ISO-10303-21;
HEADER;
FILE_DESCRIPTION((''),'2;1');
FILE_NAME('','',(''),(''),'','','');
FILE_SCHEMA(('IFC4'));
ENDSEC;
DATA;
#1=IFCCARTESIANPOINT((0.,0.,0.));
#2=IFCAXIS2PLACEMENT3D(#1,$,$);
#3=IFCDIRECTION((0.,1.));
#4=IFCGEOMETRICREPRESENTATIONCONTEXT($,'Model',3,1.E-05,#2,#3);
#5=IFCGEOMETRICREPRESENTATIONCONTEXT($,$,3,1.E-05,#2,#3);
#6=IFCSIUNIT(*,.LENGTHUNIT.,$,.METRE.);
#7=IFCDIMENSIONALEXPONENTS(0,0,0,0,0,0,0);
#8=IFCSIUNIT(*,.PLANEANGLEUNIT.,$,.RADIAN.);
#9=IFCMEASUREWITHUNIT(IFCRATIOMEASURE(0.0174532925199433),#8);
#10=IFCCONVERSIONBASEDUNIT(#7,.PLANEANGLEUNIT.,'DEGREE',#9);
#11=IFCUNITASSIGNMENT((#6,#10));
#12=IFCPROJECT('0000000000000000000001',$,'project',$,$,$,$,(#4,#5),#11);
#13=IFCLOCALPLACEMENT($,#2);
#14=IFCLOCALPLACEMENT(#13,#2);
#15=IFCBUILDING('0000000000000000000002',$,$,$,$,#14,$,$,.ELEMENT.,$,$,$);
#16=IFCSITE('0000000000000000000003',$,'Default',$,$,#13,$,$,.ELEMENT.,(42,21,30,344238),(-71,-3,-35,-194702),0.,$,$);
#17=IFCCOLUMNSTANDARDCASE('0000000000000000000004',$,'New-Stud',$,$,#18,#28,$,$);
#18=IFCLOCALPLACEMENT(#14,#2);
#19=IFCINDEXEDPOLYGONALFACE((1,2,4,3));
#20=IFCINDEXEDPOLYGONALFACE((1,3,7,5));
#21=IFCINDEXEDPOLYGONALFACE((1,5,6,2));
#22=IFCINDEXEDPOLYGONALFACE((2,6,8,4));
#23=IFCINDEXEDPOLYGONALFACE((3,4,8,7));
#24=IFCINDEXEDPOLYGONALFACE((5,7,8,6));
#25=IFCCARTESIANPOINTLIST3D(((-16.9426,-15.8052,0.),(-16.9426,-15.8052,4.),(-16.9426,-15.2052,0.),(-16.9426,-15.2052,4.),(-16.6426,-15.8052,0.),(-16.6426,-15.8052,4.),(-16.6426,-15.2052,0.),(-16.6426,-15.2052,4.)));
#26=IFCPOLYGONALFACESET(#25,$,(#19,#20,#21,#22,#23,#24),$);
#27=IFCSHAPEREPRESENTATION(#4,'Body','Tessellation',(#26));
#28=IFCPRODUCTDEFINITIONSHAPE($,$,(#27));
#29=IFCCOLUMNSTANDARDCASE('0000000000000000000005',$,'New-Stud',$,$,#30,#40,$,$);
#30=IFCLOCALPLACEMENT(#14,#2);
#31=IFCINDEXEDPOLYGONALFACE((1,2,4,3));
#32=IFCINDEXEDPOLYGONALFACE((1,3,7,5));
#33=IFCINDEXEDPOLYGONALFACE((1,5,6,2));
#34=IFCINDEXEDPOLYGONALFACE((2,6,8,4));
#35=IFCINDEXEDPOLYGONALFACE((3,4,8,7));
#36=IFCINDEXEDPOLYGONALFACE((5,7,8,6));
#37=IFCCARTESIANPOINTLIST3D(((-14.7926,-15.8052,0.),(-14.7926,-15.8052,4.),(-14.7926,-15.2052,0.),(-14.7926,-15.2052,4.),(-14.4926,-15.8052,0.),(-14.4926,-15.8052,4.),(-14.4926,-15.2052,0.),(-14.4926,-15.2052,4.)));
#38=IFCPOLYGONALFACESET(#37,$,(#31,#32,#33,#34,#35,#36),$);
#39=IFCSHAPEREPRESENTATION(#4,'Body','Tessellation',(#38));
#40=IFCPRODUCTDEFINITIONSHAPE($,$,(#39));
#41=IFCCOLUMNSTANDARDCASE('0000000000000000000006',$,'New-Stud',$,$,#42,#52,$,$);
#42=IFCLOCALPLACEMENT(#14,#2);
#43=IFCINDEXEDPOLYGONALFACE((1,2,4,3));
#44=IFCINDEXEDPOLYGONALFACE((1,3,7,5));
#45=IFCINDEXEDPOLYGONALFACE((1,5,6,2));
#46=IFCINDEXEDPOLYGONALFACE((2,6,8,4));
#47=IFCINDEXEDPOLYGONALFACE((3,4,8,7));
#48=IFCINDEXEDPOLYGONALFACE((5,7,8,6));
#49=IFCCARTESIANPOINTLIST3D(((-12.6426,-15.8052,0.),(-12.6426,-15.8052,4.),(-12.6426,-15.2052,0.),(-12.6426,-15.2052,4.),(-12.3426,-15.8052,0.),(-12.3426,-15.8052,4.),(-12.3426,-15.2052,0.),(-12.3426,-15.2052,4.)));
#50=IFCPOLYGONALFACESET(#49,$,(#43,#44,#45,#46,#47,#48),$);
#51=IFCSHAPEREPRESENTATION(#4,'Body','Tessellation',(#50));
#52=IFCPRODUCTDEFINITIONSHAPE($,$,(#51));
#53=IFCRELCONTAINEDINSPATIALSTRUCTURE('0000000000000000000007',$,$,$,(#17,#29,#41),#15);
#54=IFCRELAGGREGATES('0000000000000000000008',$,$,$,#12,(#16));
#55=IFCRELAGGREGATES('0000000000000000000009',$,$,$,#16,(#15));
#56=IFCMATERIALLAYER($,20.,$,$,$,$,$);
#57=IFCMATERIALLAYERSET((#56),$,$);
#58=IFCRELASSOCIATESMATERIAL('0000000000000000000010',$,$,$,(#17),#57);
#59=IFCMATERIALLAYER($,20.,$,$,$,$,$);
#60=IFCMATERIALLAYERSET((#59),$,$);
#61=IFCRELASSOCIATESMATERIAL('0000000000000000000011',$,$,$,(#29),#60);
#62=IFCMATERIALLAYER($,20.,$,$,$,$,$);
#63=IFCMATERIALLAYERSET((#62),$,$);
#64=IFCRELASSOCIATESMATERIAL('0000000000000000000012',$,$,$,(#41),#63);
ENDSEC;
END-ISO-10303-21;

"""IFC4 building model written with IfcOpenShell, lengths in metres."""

from ifc_helpers import new_model, entity, si_unit, converted_unit, direction, frame, origin, origin_with_axes, origin_2d, place, context, project, spatial, rectangle, extrude, layer, layer_set, layer_usage, element, save


model = new_model("IFC4")

# Units and contexts
model_context = context("Model", 3, precision=1e-05, world=origin(), true_north=direction((0.0, 1.0)))
context_of_model = context(None, 3, precision=1e-05, world=origin(), true_north=direction((0.0, 1.0)))
ifc_project = project(units=[si_unit("LENGTHUNIT", "METRE"), converted_unit("PLANEANGLEUNIT", "DEGREE", entity("IfcRatioMeasure", 0.0174532925199433), si_unit("PLANEANGLEUNIT", "RADIAN"), dimensions=[0, 0, 0, 0, 0, 0, 0])], contexts=[model_context, context_of_model])

# Site, building
site_placement = place(None, origin())
site = spatial("IfcSite", under=ifc_project, at=site_placement, Name="Default", CompositionType="ELEMENT", RefLatitude=(42, 21, 30, 344238), RefLongitude=(-71, -3, -35, -194702), RefElevation=0.0)
building_placement = place(site_placement, origin())
building = spatial("IfcBuilding", under=site, at=building_placement, CompositionType="ELEMENT")

# Columns
ifc_layer_1 = layer(None, 20.0)
ifc_layer_set_1 = layer_set([ifc_layer_1])
ifc_layer_usage_1 = layer_usage(ifc_layer_set_1, "AXIS2", "POSITIVE", 150.0)
placement_1 = place(building_placement, origin())
placement_2 = place(placement_1, frame((-16.7926, -15.5052, 0.0), z_axis=(0.0, 0.0, 1.0), x_axis=(0.0, 1.0, 0.0)))
column_1_placement = place(placement_2, origin_with_axes())
element("IfcColumnStandardCase", 1, at=column_1_placement, inside=building, material=ifc_layer_usage_1, Name="New-Stud", context=model_context, shape_type="SweptSolid", body=[
    extrude(rectangle(XDim=0.6, YDim=0.3, at=origin_2d()), origin(), (0.0, 0.0, 1.0), 4.0),
])
ifc_layer_2 = layer(None, 20.0)
ifc_layer_set_2 = layer_set([ifc_layer_2])
ifc_layer_usage_2 = layer_usage(ifc_layer_set_2, "AXIS2", "POSITIVE", 150.0)
placement_3 = place(placement_1, frame((-14.6426, -15.5052, 0.0), z_axis=(0.0, 0.0, 1.0), x_axis=(0.0, 1.0, 0.0)))
column_2_placement = place(placement_3, origin_with_axes())
element("IfcColumnStandardCase", 2, at=column_2_placement, inside=building, material=ifc_layer_usage_2, Name="New-Stud", context=model_context, shape_type="SweptSolid", body=[
    extrude(rectangle(XDim=0.6, YDim=0.3, at=origin_2d()), origin(), (0.0, 0.0, 1.0), 4.0),
])
ifc_layer_3 = layer(None, 20.0)
ifc_layer_set_3 = layer_set([ifc_layer_3])
ifc_layer_usage_3 = layer_usage(ifc_layer_set_3, "AXIS2", "POSITIVE", 150.0)
placement_4 = place(placement_1, frame((-12.4926, -15.5052, 0.0), z_axis=(0.0, 0.0, 1.0), x_axis=(0.0, 1.0, 0.0)))
column_3_placement = place(placement_4, origin_with_axes())
element("IfcColumnStandardCase", 3, at=column_3_placement, inside=building, material=ifc_layer_usage_3, Name="New-Stud", context=model_context, shape_type="SweptSolid", body=[
    extrude(rectangle(XDim=0.6, YDim=0.3, at=origin_2d()), origin(), (0.0, 0.0, 1.0), 4.0),
])

save(model, "model.ifc")
